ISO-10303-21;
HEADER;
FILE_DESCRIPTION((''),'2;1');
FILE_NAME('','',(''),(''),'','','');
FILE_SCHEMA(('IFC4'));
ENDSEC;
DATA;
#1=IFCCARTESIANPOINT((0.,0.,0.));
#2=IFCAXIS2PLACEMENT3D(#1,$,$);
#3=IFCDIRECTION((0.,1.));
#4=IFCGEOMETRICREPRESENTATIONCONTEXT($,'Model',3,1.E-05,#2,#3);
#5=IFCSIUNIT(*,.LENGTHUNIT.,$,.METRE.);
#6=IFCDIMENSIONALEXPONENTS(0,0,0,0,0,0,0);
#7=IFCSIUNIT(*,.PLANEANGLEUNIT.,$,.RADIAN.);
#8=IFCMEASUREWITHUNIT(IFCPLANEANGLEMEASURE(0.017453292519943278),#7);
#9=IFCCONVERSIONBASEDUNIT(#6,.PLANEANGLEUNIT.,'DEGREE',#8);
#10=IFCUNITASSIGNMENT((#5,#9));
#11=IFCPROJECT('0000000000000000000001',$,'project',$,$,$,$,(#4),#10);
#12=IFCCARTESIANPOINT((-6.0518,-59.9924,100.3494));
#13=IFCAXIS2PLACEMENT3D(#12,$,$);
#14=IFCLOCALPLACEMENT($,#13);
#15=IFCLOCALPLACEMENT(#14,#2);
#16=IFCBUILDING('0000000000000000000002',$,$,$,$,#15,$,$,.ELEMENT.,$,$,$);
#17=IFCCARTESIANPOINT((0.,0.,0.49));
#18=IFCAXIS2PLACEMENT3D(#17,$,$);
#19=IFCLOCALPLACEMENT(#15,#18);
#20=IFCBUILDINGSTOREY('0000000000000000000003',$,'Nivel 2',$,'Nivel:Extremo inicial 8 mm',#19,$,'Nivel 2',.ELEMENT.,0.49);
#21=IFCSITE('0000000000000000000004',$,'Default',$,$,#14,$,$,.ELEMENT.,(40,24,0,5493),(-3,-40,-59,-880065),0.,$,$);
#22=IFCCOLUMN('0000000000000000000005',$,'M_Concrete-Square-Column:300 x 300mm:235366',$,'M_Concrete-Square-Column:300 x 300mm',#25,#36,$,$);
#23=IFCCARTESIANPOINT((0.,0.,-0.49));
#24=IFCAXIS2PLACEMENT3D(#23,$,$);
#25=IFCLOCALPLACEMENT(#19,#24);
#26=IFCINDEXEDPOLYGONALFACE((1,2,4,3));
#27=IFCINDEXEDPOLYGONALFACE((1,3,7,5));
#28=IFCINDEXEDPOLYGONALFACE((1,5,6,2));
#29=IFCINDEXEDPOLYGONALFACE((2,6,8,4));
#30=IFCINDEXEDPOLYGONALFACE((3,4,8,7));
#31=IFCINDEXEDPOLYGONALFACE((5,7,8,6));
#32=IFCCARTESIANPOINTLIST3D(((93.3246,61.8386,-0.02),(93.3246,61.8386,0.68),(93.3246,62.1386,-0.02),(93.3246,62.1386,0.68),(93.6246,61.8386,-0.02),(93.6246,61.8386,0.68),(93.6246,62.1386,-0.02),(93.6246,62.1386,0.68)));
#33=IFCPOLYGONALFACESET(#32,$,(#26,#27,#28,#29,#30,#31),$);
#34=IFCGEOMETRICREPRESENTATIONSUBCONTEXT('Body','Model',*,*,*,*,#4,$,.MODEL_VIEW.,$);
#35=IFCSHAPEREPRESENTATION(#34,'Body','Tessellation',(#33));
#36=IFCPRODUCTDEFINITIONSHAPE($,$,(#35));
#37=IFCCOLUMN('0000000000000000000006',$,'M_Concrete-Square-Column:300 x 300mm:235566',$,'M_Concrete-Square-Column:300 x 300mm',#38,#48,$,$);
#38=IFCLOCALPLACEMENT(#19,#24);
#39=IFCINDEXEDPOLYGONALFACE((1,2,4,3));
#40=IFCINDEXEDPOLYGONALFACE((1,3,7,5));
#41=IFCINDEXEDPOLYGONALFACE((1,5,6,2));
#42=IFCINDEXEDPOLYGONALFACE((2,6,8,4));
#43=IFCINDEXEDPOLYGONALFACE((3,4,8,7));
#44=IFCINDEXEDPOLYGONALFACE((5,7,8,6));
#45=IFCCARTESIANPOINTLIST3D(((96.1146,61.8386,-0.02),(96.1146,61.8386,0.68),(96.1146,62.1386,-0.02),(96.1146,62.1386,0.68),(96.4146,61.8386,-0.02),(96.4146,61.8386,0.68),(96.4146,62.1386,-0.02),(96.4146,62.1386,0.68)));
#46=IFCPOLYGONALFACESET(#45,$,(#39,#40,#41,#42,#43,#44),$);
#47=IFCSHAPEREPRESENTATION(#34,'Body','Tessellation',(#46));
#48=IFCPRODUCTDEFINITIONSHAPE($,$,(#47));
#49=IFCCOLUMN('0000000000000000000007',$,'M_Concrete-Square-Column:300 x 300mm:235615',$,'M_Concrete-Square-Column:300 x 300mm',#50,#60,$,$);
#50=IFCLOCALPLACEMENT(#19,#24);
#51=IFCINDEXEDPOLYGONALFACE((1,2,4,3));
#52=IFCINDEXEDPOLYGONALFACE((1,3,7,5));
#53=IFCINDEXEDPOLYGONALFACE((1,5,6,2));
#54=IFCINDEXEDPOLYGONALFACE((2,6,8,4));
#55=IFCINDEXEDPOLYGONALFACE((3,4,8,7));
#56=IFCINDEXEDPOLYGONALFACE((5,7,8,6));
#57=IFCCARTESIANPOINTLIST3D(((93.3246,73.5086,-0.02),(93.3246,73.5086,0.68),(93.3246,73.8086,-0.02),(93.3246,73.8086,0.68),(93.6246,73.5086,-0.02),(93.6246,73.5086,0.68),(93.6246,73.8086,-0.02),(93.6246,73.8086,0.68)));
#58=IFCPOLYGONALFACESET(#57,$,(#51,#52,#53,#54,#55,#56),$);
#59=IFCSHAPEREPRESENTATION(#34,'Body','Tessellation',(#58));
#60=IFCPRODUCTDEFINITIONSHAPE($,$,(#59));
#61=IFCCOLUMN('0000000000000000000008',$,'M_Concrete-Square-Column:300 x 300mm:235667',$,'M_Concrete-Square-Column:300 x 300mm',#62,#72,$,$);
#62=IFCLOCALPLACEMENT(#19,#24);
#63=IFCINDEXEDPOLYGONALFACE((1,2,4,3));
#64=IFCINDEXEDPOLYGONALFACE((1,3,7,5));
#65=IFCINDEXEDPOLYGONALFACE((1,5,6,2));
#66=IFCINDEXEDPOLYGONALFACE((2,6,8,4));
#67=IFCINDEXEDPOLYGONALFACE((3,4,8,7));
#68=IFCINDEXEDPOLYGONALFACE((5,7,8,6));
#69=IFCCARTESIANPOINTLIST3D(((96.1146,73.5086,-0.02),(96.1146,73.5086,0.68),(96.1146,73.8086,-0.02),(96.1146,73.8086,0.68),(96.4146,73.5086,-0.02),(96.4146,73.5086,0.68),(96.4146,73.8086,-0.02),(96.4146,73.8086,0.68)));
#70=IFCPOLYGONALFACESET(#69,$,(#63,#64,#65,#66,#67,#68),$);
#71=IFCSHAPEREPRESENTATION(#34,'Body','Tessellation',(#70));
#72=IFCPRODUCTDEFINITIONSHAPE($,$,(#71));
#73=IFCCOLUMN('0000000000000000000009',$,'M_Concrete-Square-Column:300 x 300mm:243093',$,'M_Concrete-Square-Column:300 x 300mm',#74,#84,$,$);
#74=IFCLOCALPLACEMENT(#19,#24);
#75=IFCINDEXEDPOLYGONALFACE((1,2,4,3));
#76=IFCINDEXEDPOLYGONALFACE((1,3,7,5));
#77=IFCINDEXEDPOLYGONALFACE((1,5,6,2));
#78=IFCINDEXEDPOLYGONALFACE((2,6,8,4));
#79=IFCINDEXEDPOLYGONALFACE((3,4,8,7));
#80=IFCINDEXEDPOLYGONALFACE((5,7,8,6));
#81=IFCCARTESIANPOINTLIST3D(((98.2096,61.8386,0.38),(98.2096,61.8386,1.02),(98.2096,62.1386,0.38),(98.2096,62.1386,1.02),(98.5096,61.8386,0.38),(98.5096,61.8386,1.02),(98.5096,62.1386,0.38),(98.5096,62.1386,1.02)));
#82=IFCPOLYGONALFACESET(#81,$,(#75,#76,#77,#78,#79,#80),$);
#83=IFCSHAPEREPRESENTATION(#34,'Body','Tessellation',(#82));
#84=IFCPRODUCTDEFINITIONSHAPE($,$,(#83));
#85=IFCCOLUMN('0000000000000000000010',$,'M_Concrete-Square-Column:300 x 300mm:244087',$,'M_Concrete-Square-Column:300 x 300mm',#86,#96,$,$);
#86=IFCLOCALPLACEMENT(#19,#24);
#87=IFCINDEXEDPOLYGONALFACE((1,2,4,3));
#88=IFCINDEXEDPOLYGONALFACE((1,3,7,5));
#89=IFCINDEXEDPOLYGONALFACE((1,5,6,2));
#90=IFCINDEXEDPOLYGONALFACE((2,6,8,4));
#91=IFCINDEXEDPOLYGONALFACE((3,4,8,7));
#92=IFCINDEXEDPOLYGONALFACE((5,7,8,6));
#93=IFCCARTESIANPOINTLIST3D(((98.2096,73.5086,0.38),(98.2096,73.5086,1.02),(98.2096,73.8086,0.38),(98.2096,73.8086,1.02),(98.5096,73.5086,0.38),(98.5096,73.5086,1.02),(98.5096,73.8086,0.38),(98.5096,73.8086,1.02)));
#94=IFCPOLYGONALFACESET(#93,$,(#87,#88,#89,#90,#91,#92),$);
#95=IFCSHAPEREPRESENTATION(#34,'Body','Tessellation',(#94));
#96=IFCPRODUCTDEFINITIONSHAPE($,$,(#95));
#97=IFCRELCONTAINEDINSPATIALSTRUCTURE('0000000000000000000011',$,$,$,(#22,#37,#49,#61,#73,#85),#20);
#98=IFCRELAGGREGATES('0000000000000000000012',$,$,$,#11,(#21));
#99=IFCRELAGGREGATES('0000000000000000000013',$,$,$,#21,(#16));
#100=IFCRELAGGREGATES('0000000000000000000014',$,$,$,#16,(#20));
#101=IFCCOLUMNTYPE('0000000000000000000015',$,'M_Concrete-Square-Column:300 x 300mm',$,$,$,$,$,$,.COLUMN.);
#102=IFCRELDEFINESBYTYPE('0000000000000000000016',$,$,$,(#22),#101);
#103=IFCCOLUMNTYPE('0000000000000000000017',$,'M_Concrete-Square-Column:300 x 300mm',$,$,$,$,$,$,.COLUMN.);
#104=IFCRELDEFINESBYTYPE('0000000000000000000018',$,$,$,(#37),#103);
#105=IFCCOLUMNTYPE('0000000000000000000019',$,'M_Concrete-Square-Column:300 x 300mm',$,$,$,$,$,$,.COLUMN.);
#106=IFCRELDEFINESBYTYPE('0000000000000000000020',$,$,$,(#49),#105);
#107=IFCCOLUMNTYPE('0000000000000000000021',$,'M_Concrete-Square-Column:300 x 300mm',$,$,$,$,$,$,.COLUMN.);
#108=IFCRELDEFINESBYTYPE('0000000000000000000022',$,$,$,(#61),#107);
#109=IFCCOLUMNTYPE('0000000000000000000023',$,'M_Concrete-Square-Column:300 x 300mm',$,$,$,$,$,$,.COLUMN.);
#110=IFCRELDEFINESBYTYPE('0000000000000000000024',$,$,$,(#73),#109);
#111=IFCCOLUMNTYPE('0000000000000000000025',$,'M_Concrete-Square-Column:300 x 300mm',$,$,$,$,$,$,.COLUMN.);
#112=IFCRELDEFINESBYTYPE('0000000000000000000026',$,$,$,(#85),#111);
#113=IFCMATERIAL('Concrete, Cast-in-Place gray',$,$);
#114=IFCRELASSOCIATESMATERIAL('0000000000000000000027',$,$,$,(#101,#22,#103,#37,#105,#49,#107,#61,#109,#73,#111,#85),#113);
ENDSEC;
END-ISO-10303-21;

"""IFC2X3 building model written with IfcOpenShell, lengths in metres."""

from ifc_helpers import new_model, entity, si_unit, converted_unit, direction, frame, origin, origin_2d_with_axis, place, context, subcontext, project, spatial, rectangle, extrude, source, transform, mapped, material, type_object, type_shapes, element, save


model = new_model("IFC2X3")

# Units and contexts
model_context = context("Model", 3, precision=1e-05, world=origin(), true_north=direction((0.0, 1.0)))
body_context = subcontext(model_context, "Body", "Model", "MODEL_VIEW")
ifc_project = project(units=[si_unit("LENGTHUNIT", "METRE"), converted_unit("PLANEANGLEUNIT", "DEGREE", entity("IfcPlaneAngleMeasure", 0.017453292519943278), si_unit("PLANEANGLEUNIT", "RADIAN"), dimensions=[0, 0, 0, 0, 0, 0, 0])], contexts=[model_context])

# Site, building, storey
site_placement = place(None, frame((-6.0518, -59.9924, 100.3494)))
site = spatial("IfcSite", under=ifc_project, at=site_placement, Name="Default", CompositionType="ELEMENT", RefLatitude=(40, 24, 0, 5493), RefLongitude=(-3, -40, -59, -880065), RefElevation=0.0)
building_placement = place(site_placement, origin())
building = spatial("IfcBuilding", under=site, at=building_placement, CompositionType="ELEMENT")
storey_placement = place(building_placement, frame((0.0, 0.0, 0.49)))
storey = spatial("IfcBuildingStorey", under=building, at=storey_placement, Name="Nivel 2", ObjectType="Nivel:Extremo inicial 8 mm", LongName="Nivel 2", CompositionType="ELEMENT", Elevation=0.49)

# Columns
ifc_material_1 = material(Name="Concrete, Cast-in-Place gray")
column_type_1 = type_object("IfcColumnType", Name="M_Concrete-Square-Column:300 x 300mm", PredefinedType="COLUMN", material=ifc_material_1)
shared_shape_1 = source(origin(), body_context, "Body", "SweptSolid", [
    extrude(rectangle(XDim=0.3, YDim=0.3, at=origin_2d_with_axis()), frame((93.4746, 61.9886, -0.02), z_axis=(0.0, 0.0, 1.0), x_axis=(-1.0, 0.0, 0.0)), (0.0, 0.0, 1.0), 0.7),
])
type_shapes(column_type_1, [shared_shape_1])
column_1_placement = place(storey_placement, frame((0.0, 0.0, -0.49)))
element("IfcColumn", 1, at=column_1_placement, inside=storey, type_object=column_type_1, material=ifc_material_1, Name="M_Concrete-Square-Column:300 x 300mm:235366", ObjectType="M_Concrete-Square-Column:300 x 300mm", context=body_context, shape_type="MappedRepresentation", body=[
    mapped(shared_shape_1, transform((0.0, 0.0, 0.0), scale=1.0)),
])
column_type_2 = type_object("IfcColumnType", Name="M_Concrete-Square-Column:300 x 300mm", PredefinedType="COLUMN", material=ifc_material_1)
shared_shape_2 = source(origin(), body_context, "Body", "SweptSolid", [
    extrude(rectangle(XDim=0.3, YDim=0.3, at=origin_2d_with_axis()), frame((96.2646, 61.9886, -0.02), z_axis=(0.0, 0.0, 1.0), x_axis=(-1.0, 0.0, 0.0)), (0.0, 0.0, 1.0), 0.7),
])
type_shapes(column_type_2, [shared_shape_2])
column_2_placement = place(storey_placement, frame((0.0, 0.0, -0.49)))
element("IfcColumn", 2, at=column_2_placement, inside=storey, type_object=column_type_2, material=ifc_material_1, Name="M_Concrete-Square-Column:300 x 300mm:235566", ObjectType="M_Concrete-Square-Column:300 x 300mm", context=body_context, shape_type="MappedRepresentation", body=[
    mapped(shared_shape_2, transform((0.0, 0.0, 0.0), scale=1.0)),
])
column_type_3 = type_object("IfcColumnType", Name="M_Concrete-Square-Column:300 x 300mm", PredefinedType="COLUMN", material=ifc_material_1)
shared_shape_3 = source(origin(), body_context, "Body", "SweptSolid", [
    extrude(rectangle(XDim=0.3, YDim=0.3, at=origin_2d_with_axis()), frame((93.4746, 73.6586, -0.02), z_axis=(0.0, 0.0, 1.0), x_axis=(-1.0, 0.0, 0.0)), (0.0, 0.0, 1.0), 0.7),
])
type_shapes(column_type_3, [shared_shape_3])
column_3_placement = place(storey_placement, frame((0.0, 0.0, -0.49)))
element("IfcColumn", 3, at=column_3_placement, inside=storey, type_object=column_type_3, material=ifc_material_1, Name="M_Concrete-Square-Column:300 x 300mm:235615", ObjectType="M_Concrete-Square-Column:300 x 300mm", context=body_context, shape_type="MappedRepresentation", body=[
    mapped(shared_shape_3, transform((0.0, 0.0, 0.0), scale=1.0)),
])
column_type_4 = type_object("IfcColumnType", Name="M_Concrete-Square-Column:300 x 300mm", PredefinedType="COLUMN", material=ifc_material_1)
shared_shape_4 = source(origin(), body_context, "Body", "SweptSolid", [
    extrude(rectangle(XDim=0.3, YDim=0.3, at=origin_2d_with_axis()), frame((96.2646, 73.6586, -0.02), z_axis=(0.0, 0.0, 1.0), x_axis=(-1.0, 0.0, 0.0)), (0.0, 0.0, 1.0), 0.7),
])
type_shapes(column_type_4, [shared_shape_4])
column_4_placement = place(storey_placement, frame((0.0, 0.0, -0.49)))
element("IfcColumn", 4, at=column_4_placement, inside=storey, type_object=column_type_4, material=ifc_material_1, Name="M_Concrete-Square-Column:300 x 300mm:235667", ObjectType="M_Concrete-Square-Column:300 x 300mm", context=body_context, shape_type="MappedRepresentation", body=[
    mapped(shared_shape_4, transform((0.0, 0.0, 0.0), scale=1.0)),
])
column_type_5 = type_object("IfcColumnType", Name="M_Concrete-Square-Column:300 x 300mm", PredefinedType="COLUMN", material=ifc_material_1)
shared_shape_5 = source(origin(), body_context, "Body", "SweptSolid", [
    extrude(rectangle(XDim=0.3, YDim=0.3, at=origin_2d_with_axis()), frame((98.3596, 61.9886, 0.38), z_axis=(0.0, 0.0, 1.0), x_axis=(-1.0, 0.0, 0.0)), (0.0, 0.0, 1.0), 0.64),
])
type_shapes(column_type_5, [shared_shape_5])
column_5_placement = place(storey_placement, frame((0.0, 0.0, -0.49)))
element("IfcColumn", 5, at=column_5_placement, inside=storey, type_object=column_type_5, material=ifc_material_1, Name="M_Concrete-Square-Column:300 x 300mm:243093", ObjectType="M_Concrete-Square-Column:300 x 300mm", context=body_context, shape_type="MappedRepresentation", body=[
    mapped(shared_shape_5, transform((0.0, 0.0, 0.0), scale=1.0)),
])
column_type_6 = type_object("IfcColumnType", Name="M_Concrete-Square-Column:300 x 300mm", PredefinedType="COLUMN", material=ifc_material_1)
shared_shape_6 = source(origin(), body_context, "Body", "SweptSolid", [
    extrude(rectangle(XDim=0.3, YDim=0.3, at=origin_2d_with_axis()), frame((98.3596, 73.6586, 0.38), z_axis=(0.0, 0.0, 1.0), x_axis=(-1.0, 0.0, 0.0)), (0.0, 0.0, 1.0), 0.64),
])
type_shapes(column_type_6, [shared_shape_6])
column_6_placement = place(storey_placement, frame((0.0, 0.0, -0.49)))
element("IfcColumn", 6, at=column_6_placement, inside=storey, type_object=column_type_6, material=ifc_material_1, Name="M_Concrete-Square-Column:300 x 300mm:244087", ObjectType="M_Concrete-Square-Column:300 x 300mm", context=body_context, shape_type="MappedRepresentation", body=[
    mapped(shared_shape_6, transform((0.0, 0.0, 0.0), scale=1.0)),
])

save(model, "model.ifc")
